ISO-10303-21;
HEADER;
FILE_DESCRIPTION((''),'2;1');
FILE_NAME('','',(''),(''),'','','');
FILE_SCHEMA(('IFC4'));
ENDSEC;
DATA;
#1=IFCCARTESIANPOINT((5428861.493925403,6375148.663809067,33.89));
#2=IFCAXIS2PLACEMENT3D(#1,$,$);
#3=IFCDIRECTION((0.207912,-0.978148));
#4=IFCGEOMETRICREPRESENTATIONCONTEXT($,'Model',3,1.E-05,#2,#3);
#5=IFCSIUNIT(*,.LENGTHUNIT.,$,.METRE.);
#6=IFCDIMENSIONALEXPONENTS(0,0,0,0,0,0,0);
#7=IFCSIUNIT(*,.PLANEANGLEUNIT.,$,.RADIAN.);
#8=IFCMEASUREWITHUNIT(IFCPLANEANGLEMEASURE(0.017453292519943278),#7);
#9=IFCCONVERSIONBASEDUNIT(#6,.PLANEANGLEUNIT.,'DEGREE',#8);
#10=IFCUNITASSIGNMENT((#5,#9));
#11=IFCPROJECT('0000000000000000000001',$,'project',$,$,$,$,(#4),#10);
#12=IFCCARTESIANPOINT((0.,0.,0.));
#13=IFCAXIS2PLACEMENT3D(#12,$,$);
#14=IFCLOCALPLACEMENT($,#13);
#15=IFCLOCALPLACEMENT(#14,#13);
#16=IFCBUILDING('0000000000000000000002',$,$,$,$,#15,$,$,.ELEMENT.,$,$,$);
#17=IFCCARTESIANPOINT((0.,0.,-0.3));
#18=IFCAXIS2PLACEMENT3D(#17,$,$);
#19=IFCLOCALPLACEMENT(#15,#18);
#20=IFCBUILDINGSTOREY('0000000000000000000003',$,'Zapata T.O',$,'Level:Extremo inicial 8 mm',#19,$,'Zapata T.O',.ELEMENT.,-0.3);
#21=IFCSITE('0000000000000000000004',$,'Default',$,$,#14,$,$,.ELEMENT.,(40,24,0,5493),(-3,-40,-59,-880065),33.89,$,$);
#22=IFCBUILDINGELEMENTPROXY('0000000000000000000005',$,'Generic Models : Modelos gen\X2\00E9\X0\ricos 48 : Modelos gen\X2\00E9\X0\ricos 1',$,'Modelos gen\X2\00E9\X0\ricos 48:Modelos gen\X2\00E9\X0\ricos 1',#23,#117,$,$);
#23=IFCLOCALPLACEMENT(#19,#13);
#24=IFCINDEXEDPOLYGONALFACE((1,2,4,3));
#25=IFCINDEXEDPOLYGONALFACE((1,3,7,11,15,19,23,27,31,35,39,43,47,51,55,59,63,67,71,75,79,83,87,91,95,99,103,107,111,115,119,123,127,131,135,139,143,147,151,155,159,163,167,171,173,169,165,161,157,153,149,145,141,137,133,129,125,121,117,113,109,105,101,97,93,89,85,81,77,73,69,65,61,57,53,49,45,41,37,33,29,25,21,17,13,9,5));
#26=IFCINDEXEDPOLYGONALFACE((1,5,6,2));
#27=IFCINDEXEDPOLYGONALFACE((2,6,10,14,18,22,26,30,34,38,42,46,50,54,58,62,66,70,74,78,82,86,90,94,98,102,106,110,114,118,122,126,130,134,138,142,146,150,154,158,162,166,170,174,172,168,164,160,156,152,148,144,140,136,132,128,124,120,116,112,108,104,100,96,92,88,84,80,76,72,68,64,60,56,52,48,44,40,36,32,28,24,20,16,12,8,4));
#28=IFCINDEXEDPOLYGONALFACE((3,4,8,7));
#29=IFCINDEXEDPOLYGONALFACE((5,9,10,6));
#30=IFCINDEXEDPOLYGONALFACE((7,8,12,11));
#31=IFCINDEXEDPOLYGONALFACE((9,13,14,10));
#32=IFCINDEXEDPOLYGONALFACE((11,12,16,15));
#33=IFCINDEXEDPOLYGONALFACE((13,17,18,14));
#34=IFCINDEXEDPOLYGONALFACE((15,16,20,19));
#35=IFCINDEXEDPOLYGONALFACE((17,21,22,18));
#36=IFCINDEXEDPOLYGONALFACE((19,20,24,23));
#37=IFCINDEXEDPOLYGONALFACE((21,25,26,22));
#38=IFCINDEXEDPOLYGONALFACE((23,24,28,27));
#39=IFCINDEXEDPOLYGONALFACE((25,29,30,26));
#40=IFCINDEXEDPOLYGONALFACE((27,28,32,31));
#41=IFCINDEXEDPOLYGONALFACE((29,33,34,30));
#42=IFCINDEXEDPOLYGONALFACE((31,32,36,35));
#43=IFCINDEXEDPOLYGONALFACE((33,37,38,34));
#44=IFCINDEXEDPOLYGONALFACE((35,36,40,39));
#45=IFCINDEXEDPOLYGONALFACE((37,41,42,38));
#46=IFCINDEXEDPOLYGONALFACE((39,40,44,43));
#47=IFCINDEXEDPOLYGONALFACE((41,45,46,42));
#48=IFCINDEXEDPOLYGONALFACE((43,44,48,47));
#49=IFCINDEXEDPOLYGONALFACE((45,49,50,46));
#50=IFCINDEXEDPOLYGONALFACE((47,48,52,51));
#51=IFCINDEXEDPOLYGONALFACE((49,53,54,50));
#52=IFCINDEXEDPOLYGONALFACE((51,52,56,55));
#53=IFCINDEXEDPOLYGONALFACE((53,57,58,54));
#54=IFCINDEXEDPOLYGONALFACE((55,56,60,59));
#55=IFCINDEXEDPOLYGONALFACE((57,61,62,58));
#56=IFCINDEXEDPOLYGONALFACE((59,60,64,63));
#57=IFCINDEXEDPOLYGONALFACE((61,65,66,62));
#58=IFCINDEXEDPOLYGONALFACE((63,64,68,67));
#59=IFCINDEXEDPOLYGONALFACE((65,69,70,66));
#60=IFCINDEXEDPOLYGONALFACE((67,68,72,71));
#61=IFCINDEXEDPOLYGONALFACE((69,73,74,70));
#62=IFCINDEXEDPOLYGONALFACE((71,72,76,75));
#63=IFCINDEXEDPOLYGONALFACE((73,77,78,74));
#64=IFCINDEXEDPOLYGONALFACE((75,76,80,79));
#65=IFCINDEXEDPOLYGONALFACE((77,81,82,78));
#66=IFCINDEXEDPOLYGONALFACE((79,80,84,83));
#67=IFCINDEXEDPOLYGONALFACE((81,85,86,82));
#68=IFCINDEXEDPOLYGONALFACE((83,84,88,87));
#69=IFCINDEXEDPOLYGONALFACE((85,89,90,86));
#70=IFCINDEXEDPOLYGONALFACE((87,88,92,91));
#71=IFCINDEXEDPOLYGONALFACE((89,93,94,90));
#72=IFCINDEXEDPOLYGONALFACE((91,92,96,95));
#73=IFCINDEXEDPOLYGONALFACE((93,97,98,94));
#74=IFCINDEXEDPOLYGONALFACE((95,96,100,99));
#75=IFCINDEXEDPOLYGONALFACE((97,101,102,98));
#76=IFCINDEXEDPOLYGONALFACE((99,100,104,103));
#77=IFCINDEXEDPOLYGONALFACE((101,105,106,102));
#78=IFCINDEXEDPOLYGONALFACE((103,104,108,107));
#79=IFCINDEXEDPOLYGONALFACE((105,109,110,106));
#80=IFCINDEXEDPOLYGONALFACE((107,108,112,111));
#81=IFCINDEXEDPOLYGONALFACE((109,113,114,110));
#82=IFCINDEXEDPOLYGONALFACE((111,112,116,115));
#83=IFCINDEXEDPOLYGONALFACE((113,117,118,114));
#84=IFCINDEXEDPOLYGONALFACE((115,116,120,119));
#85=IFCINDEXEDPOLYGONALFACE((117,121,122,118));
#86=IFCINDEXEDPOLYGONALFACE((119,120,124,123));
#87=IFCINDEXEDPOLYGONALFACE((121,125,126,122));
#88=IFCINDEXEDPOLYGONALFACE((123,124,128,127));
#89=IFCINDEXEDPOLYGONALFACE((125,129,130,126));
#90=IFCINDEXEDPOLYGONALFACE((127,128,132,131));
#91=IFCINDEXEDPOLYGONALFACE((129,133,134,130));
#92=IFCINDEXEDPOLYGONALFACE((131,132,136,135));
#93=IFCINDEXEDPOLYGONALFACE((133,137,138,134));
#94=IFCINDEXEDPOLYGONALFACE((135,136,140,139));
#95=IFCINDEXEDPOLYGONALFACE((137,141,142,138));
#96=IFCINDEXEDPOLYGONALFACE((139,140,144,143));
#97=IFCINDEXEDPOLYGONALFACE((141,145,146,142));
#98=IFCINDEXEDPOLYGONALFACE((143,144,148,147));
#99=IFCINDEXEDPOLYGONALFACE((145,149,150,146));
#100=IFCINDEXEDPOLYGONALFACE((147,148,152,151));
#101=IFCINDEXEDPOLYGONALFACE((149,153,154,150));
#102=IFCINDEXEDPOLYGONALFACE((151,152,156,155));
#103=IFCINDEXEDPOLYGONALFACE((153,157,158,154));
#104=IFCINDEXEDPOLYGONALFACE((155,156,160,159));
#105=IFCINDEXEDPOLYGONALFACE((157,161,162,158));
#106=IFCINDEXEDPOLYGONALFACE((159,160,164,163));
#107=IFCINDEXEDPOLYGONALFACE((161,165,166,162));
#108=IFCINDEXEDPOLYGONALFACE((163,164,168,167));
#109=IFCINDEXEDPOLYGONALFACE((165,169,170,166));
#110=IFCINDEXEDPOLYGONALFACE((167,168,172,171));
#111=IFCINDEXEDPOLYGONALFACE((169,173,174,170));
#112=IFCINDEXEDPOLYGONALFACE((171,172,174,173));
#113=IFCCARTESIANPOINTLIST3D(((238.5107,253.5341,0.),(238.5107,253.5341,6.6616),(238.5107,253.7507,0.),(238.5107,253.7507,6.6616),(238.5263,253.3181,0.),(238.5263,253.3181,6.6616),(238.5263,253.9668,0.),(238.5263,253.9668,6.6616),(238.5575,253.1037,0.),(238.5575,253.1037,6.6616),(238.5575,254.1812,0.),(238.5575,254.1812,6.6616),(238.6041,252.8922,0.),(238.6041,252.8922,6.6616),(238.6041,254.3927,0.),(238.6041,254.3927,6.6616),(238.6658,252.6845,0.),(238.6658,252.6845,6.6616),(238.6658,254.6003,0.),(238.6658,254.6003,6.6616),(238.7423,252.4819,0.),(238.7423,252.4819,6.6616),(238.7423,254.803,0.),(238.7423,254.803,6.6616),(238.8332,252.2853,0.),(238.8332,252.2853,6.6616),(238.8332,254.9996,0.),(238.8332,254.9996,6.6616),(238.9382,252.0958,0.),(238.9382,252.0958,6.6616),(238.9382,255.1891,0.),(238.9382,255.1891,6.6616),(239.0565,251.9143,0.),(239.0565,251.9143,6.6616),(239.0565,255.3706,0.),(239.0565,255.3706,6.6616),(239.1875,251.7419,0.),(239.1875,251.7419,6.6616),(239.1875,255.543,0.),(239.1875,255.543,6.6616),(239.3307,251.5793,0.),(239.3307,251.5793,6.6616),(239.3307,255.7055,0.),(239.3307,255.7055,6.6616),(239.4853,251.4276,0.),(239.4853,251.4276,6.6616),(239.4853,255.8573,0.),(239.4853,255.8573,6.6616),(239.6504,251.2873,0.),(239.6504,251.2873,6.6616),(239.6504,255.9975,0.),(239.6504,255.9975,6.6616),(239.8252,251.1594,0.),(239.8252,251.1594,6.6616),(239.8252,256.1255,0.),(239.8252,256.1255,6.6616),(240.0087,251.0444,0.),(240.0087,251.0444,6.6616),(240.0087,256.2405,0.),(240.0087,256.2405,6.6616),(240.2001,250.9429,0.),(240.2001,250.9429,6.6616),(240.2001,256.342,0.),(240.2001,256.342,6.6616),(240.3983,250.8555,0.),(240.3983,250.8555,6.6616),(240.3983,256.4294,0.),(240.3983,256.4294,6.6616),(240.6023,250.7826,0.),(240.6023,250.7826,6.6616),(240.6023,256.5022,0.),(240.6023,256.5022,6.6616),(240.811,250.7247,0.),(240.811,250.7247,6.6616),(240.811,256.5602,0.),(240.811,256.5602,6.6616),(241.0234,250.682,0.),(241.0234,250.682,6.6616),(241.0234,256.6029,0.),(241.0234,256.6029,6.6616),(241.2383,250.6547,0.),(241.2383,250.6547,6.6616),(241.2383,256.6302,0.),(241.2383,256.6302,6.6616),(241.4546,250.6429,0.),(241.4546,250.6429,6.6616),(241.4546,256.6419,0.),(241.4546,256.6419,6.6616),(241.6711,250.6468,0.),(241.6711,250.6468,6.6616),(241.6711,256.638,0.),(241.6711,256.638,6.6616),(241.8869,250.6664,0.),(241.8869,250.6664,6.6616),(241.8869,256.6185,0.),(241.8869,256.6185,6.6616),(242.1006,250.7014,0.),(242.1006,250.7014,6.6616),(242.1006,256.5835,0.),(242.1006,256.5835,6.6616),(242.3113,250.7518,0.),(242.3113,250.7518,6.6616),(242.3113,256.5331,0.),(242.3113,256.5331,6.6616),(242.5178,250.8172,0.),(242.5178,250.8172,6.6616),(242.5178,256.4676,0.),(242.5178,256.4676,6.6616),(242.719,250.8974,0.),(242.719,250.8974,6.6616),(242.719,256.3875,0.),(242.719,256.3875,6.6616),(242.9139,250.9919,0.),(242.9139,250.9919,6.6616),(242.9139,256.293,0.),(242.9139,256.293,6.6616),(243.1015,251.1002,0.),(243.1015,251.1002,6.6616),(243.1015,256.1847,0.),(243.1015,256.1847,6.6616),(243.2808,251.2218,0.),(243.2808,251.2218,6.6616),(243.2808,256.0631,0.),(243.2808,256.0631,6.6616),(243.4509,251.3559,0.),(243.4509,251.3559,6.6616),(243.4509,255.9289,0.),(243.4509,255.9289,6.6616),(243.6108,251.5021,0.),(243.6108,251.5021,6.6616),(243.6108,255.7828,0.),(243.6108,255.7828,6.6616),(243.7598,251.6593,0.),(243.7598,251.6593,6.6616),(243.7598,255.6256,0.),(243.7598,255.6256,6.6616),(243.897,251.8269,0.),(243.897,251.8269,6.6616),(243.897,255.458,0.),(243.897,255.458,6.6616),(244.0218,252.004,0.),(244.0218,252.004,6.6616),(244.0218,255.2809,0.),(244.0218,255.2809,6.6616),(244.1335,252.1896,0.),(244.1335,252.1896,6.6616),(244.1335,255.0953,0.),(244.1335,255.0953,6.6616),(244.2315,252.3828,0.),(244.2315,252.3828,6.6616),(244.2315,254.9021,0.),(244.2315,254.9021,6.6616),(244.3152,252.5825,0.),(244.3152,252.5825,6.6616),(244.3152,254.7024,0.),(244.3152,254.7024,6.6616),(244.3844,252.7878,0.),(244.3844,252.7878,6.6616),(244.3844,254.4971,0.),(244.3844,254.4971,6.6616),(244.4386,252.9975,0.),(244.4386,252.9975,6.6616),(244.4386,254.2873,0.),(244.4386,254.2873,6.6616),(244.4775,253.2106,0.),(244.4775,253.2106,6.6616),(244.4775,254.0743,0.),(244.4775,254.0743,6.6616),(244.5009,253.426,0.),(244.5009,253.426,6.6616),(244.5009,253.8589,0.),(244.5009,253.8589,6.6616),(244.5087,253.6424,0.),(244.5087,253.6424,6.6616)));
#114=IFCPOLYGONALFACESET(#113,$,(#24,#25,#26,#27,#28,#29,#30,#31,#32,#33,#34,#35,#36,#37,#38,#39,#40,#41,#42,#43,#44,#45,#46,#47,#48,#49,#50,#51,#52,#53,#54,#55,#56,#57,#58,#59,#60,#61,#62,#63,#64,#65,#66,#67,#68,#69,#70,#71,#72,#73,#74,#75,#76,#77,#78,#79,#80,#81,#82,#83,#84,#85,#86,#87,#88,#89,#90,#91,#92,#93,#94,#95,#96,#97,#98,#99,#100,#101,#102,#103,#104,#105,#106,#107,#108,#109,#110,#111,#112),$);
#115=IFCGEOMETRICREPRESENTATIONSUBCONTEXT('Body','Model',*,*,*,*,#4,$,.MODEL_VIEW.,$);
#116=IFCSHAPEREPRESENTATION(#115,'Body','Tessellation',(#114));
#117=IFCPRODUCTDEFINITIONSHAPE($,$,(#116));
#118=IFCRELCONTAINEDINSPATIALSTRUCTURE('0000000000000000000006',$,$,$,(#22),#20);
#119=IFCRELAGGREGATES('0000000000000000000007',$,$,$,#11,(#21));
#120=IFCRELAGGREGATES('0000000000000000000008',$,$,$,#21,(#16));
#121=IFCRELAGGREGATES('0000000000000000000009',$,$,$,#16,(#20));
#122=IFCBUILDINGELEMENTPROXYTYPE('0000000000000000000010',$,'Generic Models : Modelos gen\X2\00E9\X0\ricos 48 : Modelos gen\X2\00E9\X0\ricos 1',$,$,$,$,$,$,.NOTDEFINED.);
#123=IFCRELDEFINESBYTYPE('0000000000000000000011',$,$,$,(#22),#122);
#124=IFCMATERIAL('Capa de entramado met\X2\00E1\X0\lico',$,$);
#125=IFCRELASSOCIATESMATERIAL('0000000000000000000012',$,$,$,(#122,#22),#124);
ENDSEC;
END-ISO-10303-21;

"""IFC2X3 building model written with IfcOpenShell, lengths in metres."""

from ifc_helpers import new_model, entity, si_unit, converted_unit, direction, frame, origin, origin_2d_with_axis, place, context, subcontext, project, spatial, circle, extrude, source, transform, mapped, material, type_object, type_shapes, element, save


model = new_model("IFC2X3")

# Units and contexts
model_context = context("Model", 3, precision=1e-05, world=frame((5428861.493925403, 6375148.663809067, 33.89)), true_north=direction((0.207912, -0.978148)))
body_context = subcontext(model_context, "Body", "Model", "MODEL_VIEW")
ifc_project = project(units=[si_unit("LENGTHUNIT", "METRE"), converted_unit("PLANEANGLEUNIT", "DEGREE", entity("IfcPlaneAngleMeasure", 0.017453292519943278), si_unit("PLANEANGLEUNIT", "RADIAN"), dimensions=[0, 0, 0, 0, 0, 0, 0])], contexts=[model_context])

# Site, building, storey
site_placement = place(None, origin())
site = spatial("IfcSite", under=ifc_project, at=site_placement, Name="Default", CompositionType="ELEMENT", RefLatitude=(40, 24, 0, 5493), RefLongitude=(-3, -40, -59, -880065), RefElevation=33.89)
building_placement = place(site_placement, origin())
building = spatial("IfcBuilding", under=site, at=building_placement, CompositionType="ELEMENT")
storey_placement = place(building_placement, frame((0.0, 0.0, -0.3)))
storey = spatial("IfcBuildingStorey", under=building, at=storey_placement, Name="Zapata T.O", ObjectType="Level:Extremo inicial 8 mm", LongName="Zapata T.O", CompositionType="ELEMENT", Elevation=-0.3)

# Building element proxy
ifc_material = material(Name="Capa de entramado metálico")
building_element_proxy_type_1 = type_object("IfcBuildingElementProxyType", Name="Generic Models : Modelos genéricos 48 : Modelos genéricos 1", PredefinedType="NOTDEFINED", material=ifc_material)
shared_shape_1 = source(origin(), body_context, "Body", "SweptSolid", [
    extrude(circle(Radius=3.0, at=origin_2d_with_axis()), frame((241.5087, 253.6424, -0.3)), (0.0, 0.0, 1.0), 6.6616),
])
type_shapes(building_element_proxy_type_1, [shared_shape_1])
proxy_1_placement = place(storey_placement, frame((0.0, 0.0, 0.3)))
element("IfcBuildingElementProxy", 1, at=proxy_1_placement, inside=storey, type_object=building_element_proxy_type_1, material=ifc_material, Name="Generic Models : Modelos genéricos 48 : Modelos genéricos 1", ObjectType="Modelos genéricos 48:Modelos genéricos 1", context=body_context, shape_type="MappedRepresentation", body=[
    mapped(shared_shape_1, transform((0.0, 0.0, 0.0), scale=1.0)),
])

save(model, "model.ifc")
